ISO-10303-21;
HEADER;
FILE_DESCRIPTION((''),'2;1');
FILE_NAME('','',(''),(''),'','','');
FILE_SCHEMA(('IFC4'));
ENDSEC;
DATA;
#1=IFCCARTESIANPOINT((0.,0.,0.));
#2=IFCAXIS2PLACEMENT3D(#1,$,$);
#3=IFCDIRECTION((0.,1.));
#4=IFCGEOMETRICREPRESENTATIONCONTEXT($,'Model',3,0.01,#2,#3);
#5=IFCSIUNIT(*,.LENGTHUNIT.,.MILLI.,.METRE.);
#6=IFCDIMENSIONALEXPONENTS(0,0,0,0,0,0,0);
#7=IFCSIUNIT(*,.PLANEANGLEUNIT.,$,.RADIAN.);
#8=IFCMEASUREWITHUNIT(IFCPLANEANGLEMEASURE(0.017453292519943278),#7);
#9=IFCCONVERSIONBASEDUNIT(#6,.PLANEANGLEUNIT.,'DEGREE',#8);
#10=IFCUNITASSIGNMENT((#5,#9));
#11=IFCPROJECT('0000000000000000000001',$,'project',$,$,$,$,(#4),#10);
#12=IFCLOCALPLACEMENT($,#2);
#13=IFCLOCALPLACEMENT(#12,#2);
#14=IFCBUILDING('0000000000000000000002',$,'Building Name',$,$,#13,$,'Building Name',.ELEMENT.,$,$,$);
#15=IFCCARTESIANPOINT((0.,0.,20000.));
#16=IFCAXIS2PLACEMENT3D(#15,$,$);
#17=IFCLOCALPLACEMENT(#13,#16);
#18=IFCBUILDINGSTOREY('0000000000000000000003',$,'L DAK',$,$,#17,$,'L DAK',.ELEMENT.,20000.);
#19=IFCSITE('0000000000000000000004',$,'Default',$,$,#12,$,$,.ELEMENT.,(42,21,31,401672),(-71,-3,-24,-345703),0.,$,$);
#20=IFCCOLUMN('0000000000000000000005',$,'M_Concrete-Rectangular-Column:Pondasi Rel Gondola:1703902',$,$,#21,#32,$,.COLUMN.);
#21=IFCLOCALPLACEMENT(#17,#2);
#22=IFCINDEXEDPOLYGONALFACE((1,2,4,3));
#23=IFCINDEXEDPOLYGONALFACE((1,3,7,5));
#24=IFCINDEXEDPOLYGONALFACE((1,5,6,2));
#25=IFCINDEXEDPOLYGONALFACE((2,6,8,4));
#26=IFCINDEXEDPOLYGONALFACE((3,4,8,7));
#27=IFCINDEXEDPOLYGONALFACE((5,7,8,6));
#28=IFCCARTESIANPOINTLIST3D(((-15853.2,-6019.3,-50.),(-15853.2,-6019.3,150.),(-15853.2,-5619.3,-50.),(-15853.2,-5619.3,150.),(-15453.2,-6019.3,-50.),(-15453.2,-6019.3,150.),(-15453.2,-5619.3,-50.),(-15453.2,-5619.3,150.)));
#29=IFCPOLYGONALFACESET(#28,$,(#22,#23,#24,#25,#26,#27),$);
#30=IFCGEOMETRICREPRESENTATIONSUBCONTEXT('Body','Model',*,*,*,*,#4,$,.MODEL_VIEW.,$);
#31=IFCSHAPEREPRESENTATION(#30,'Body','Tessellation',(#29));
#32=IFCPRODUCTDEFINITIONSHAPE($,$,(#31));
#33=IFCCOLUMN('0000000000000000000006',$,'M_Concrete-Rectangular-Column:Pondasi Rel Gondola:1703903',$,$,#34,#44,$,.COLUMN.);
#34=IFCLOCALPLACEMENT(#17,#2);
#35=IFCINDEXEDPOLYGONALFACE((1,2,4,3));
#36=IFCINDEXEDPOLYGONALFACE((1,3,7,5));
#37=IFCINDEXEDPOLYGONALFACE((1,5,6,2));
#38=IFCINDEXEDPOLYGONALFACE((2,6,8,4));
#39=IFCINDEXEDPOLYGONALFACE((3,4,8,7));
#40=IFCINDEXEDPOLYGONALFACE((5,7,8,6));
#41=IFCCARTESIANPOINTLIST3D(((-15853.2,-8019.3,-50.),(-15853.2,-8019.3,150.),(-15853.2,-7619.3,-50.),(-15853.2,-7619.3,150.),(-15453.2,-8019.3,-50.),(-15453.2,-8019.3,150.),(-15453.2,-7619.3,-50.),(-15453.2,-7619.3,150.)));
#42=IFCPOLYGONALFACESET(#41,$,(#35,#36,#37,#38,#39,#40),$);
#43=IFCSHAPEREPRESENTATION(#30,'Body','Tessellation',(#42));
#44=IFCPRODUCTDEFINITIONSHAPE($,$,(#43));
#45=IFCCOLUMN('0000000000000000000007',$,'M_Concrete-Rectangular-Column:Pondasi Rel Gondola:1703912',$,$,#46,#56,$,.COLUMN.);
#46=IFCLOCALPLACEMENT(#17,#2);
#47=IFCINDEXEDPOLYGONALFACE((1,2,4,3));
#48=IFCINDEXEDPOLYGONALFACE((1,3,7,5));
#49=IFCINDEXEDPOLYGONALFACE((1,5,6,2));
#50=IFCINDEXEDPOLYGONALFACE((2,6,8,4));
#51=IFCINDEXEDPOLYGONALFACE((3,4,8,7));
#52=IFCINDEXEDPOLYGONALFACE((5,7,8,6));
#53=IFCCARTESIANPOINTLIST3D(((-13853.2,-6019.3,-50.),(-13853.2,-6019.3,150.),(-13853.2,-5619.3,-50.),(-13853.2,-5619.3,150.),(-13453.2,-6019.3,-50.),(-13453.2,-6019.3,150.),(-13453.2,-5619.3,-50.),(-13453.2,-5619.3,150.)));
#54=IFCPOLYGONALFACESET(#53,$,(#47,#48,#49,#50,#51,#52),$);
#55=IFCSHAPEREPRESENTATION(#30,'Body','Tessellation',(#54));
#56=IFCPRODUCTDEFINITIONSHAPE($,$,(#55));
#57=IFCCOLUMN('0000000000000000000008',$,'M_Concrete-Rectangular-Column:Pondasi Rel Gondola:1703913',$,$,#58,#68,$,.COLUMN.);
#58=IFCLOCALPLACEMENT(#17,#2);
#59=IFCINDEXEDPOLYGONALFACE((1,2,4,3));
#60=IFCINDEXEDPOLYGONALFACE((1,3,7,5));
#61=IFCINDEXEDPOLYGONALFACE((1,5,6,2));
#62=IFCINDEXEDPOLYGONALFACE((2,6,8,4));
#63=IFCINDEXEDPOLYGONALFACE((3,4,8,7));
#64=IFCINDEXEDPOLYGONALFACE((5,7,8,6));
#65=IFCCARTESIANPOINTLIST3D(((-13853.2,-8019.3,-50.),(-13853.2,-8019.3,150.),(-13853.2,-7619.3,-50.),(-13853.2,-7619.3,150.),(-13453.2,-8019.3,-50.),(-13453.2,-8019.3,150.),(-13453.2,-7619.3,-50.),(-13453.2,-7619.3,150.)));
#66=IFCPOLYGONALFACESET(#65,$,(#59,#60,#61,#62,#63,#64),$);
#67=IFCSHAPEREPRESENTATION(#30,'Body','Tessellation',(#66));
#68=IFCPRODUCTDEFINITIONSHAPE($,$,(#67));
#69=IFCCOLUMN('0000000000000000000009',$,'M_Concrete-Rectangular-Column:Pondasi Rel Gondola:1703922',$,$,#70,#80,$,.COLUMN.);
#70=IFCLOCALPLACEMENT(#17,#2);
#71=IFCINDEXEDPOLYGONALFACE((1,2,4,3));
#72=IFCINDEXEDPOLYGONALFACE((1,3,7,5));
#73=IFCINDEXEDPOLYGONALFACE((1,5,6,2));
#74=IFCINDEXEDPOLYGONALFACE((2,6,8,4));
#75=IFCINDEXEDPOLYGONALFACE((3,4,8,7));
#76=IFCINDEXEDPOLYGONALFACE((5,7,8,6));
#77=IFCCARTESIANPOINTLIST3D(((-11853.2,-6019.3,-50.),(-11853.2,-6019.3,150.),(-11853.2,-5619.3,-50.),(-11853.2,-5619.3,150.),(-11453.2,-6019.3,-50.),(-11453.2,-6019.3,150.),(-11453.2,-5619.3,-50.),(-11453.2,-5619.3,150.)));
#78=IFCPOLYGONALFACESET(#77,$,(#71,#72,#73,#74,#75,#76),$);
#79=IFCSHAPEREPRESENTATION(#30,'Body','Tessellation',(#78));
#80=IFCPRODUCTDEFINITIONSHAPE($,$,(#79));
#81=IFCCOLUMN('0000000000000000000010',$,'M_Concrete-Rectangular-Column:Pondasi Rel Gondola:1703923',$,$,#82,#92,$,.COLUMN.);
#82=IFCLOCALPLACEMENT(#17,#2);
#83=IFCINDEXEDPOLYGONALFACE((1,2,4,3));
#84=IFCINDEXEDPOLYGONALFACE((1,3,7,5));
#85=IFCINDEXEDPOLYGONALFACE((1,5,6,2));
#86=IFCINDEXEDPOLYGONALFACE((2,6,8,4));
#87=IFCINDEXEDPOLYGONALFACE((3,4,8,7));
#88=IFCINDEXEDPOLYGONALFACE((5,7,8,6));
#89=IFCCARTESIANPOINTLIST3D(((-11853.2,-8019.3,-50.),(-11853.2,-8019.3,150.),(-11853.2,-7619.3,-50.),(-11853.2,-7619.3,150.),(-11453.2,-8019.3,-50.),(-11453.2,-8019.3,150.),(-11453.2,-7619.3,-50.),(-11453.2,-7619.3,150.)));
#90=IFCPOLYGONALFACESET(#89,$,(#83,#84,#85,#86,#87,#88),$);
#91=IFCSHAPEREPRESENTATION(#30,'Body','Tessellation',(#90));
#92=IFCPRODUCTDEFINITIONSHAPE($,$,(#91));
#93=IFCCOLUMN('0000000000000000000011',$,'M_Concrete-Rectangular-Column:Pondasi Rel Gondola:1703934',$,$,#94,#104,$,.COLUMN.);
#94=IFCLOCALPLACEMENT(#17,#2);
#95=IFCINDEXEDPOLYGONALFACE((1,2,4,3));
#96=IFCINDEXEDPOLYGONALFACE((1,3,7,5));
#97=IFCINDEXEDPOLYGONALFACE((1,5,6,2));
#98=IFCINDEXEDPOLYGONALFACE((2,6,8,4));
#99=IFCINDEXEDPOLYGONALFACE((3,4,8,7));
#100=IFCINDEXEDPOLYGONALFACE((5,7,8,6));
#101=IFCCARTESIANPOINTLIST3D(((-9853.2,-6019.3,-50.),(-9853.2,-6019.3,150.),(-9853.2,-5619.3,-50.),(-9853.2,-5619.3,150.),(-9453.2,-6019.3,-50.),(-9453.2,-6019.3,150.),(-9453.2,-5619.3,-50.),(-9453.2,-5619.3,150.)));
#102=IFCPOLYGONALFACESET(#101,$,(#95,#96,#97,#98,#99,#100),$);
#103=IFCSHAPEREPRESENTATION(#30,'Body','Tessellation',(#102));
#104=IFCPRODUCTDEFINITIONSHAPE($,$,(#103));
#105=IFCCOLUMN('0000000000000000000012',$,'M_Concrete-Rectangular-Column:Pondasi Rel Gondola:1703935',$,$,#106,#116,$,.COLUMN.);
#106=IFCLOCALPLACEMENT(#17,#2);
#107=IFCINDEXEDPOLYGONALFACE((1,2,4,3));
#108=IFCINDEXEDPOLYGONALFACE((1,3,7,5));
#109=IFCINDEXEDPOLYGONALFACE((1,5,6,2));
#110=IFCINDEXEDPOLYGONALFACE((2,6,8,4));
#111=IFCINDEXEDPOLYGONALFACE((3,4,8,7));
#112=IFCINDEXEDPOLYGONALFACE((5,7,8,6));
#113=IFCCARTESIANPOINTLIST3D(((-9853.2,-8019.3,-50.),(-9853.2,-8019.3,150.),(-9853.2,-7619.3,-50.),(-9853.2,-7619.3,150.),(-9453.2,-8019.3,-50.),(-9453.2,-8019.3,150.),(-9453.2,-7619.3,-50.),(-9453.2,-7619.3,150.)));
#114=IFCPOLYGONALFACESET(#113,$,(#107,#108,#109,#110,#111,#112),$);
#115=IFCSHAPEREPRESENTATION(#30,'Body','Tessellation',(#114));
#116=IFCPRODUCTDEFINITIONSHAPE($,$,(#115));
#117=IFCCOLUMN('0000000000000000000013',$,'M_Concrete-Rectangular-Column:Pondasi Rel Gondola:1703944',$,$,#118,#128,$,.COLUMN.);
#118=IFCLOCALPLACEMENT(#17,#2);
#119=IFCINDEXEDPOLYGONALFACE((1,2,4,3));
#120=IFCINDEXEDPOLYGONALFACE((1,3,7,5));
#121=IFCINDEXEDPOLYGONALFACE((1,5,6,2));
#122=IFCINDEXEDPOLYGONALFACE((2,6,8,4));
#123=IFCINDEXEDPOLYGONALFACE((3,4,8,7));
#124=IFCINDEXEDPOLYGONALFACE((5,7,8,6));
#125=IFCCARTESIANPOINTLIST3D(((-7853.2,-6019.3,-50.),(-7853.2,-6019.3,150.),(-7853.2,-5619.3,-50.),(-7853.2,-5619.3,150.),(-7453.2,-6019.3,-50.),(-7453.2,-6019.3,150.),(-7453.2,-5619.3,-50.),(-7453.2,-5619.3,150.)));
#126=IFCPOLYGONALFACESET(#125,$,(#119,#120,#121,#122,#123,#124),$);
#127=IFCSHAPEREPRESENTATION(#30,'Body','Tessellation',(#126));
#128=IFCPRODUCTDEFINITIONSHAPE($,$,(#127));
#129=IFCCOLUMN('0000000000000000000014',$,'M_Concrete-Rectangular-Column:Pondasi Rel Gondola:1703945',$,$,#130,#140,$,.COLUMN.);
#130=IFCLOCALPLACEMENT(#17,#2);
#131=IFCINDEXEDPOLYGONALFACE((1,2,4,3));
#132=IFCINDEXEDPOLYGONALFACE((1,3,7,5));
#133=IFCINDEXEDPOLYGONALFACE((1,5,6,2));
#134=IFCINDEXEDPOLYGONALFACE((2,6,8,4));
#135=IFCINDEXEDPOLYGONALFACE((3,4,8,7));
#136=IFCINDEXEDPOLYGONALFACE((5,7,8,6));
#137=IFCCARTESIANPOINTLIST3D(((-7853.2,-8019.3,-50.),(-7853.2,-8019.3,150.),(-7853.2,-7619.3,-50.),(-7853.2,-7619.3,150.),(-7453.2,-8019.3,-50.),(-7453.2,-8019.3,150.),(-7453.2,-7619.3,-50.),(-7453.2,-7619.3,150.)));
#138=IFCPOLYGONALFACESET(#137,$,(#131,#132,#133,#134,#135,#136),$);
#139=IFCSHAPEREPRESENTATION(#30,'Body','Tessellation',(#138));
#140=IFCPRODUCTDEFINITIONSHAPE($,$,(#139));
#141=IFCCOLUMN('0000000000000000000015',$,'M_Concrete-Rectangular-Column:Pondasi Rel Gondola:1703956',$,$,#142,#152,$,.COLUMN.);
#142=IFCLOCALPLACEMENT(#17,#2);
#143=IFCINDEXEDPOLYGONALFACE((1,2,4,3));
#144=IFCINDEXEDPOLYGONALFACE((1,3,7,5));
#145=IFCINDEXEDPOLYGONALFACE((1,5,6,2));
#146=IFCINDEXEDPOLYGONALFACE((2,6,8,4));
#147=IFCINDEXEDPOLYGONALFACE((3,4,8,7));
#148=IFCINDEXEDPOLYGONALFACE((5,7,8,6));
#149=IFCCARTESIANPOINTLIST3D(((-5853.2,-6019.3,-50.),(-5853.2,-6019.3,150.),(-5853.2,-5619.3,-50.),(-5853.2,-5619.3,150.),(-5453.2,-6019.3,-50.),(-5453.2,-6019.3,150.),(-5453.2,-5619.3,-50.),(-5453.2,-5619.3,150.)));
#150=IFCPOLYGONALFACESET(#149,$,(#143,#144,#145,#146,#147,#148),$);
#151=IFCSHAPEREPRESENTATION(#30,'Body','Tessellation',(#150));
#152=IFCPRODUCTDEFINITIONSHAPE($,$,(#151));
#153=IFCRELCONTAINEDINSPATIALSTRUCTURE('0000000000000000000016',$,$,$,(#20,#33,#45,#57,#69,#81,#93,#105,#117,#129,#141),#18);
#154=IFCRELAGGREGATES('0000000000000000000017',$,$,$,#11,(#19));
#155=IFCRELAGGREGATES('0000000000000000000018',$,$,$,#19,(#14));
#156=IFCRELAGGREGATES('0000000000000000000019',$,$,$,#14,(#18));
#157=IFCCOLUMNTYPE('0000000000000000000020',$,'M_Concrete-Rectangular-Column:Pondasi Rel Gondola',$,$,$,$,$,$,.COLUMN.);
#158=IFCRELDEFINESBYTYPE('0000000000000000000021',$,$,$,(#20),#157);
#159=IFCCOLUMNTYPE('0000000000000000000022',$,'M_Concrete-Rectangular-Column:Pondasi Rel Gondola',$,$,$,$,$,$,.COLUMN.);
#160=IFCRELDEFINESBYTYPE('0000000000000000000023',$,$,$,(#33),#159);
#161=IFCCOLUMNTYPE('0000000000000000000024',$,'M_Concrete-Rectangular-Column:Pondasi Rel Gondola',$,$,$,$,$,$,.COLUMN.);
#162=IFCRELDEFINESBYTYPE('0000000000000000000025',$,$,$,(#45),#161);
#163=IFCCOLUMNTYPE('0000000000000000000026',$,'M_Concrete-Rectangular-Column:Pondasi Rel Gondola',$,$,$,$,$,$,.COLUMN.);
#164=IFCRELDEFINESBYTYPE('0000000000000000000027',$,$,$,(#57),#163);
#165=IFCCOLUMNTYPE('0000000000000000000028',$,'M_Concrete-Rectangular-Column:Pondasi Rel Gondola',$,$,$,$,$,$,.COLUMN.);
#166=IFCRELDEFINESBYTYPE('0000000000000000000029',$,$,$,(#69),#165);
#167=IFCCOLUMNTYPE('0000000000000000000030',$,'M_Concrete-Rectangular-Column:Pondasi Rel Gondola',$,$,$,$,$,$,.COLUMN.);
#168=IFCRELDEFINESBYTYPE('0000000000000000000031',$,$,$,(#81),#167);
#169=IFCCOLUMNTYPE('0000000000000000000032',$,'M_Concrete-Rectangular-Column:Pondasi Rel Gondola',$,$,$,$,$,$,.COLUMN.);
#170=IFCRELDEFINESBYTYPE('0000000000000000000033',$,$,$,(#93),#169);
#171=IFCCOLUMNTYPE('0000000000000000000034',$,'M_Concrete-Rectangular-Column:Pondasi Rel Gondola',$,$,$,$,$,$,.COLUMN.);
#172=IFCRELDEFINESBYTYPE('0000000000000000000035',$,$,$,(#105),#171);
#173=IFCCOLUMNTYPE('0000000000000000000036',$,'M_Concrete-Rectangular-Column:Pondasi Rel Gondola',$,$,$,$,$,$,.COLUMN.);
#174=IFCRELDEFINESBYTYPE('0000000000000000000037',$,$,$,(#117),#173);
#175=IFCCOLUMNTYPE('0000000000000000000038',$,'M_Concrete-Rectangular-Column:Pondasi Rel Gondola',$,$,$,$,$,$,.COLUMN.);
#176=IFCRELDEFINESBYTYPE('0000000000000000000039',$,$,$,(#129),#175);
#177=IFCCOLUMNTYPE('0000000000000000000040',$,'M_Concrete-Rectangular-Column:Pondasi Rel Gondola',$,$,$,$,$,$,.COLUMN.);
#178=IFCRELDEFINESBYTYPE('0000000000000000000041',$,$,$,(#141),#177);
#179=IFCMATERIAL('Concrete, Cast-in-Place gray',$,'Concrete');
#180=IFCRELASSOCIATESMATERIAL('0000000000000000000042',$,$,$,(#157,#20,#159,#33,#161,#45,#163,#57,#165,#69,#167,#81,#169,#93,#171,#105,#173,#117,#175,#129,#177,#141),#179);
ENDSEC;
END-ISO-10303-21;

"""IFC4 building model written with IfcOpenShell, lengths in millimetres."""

from ifc_helpers import new_model, entity, si_unit, converted_unit, direction, frame, origin, place, context, subcontext, project, spatial, indexed_curve, outline, extrude, source, transform, mapped, material, type_object, type_shapes, element, save


model = new_model("IFC4")

# Units and contexts
model_context = context("Model", 3, precision=0.01, world=origin(), true_north=direction((0.0, 1.0)))
body_context = subcontext(model_context, "Body", "Model", "MODEL_VIEW")
ifc_project = project(units=[si_unit("LENGTHUNIT", "METRE", prefix="MILLI"), converted_unit("PLANEANGLEUNIT", "DEGREE", entity("IfcPlaneAngleMeasure", 0.017453292519943278), si_unit("PLANEANGLEUNIT", "RADIAN"), dimensions=[0, 0, 0, 0, 0, 0, 0])], contexts=[model_context])

# Site, building, storey
site_placement = place(None, origin())
site = spatial("IfcSite", under=ifc_project, at=site_placement, Name="Default", CompositionType="ELEMENT", RefLatitude=(42, 21, 31, 401672), RefLongitude=(-71, -3, -24, -345703), RefElevation=0.0)
building_placement = place(site_placement, origin())
building = spatial("IfcBuilding", under=site, at=building_placement, Name="Building Name", LongName="Building Name", CompositionType="ELEMENT")
storey_placement = place(building_placement, frame((0.0, 0.0, 20000.0)))
storey = spatial("IfcBuildingStorey", under=building, at=storey_placement, Name="L DAK", LongName="L DAK", CompositionType="ELEMENT", Elevation=20000.0)

# Columns
ifc_material = material(Name="Concrete, Cast-in-Place gray", Category="Concrete")
column_type_1 = type_object("IfcColumnType", Name="M_Concrete-Rectangular-Column:Pondasi Rel Gondola", PredefinedType="COLUMN", material=ifc_material)
shared_shape_1 = source(origin(), body_context, "Body", "SweptSolid", [
    extrude(outline(indexed_curve([(-200.0, -200.0), (200.0, -200.0), (200.0, 200.0), (-200.0, 200.0), (-200.0, -200.0)], self_intersect=False)), frame((-15653.2, -5819.3, 19950.0), z_axis=(0.0, 0.0, 1.0), x_axis=(-1.0, 0.0, 0.0)), (0.0, 0.0, 1.0), 200.0),
])
type_shapes(column_type_1, [shared_shape_1])
column_1_placement = place(storey_placement, frame((0.0, 0.0, -20000.0)))
element("IfcColumn", 1, at=column_1_placement, inside=storey, type_object=column_type_1, material=ifc_material, Name="M_Concrete-Rectangular-Column:Pondasi Rel Gondola:1703902", PredefinedType="COLUMN", context=body_context, shape_type="MappedRepresentation", body=[
    mapped(shared_shape_1, transform((0.0, 0.0, 0.0), scale=1.0)),
])
column_type_2 = type_object("IfcColumnType", Name="M_Concrete-Rectangular-Column:Pondasi Rel Gondola", PredefinedType="COLUMN", material=ifc_material)
shared_shape_2 = source(origin(), body_context, "Body", "SweptSolid", [
    extrude(outline(indexed_curve([(-200.0, -200.0), (200.0, -200.0), (200.0, 200.0), (-200.0, 200.0), (-200.0, -200.0)], self_intersect=False)), frame((-15653.2, -7819.3, 19950.0), z_axis=(0.0, 0.0, 1.0), x_axis=(-1.0, 0.0, 0.0)), (0.0, 0.0, 1.0), 200.0),
])
type_shapes(column_type_2, [shared_shape_2])
column_2_placement = place(storey_placement, frame((0.0, 0.0, -20000.0)))
element("IfcColumn", 2, at=column_2_placement, inside=storey, type_object=column_type_2, material=ifc_material, Name="M_Concrete-Rectangular-Column:Pondasi Rel Gondola:1703903", PredefinedType="COLUMN", context=body_context, shape_type="MappedRepresentation", body=[
    mapped(shared_shape_2, transform((0.0, 0.0, 0.0), scale=1.0)),
])
column_type_3 = type_object("IfcColumnType", Name="M_Concrete-Rectangular-Column:Pondasi Rel Gondola", PredefinedType="COLUMN", material=ifc_material)
shared_shape_3 = source(origin(), body_context, "Body", "SweptSolid", [
    extrude(outline(indexed_curve([(-200.0, -200.0), (200.0, -200.0), (200.0, 200.0), (-200.0, 200.0), (-200.0, -200.0)], self_intersect=False)), frame((-13653.2, -5819.3, 19950.0), z_axis=(0.0, 0.0, 1.0), x_axis=(-1.0, 0.0, 0.0)), (0.0, 0.0, 1.0), 200.0),
])
type_shapes(column_type_3, [shared_shape_3])
column_3_placement = place(storey_placement, frame((0.0, 0.0, -20000.0)))
element("IfcColumn", 3, at=column_3_placement, inside=storey, type_object=column_type_3, material=ifc_material, Name="M_Concrete-Rectangular-Column:Pondasi Rel Gondola:1703912", PredefinedType="COLUMN", context=body_context, shape_type="MappedRepresentation", body=[
    mapped(shared_shape_3, transform((0.0, 0.0, 0.0), scale=1.0)),
])
column_type_4 = type_object("IfcColumnType", Name="M_Concrete-Rectangular-Column:Pondasi Rel Gondola", PredefinedType="COLUMN", material=ifc_material)
shared_shape_4 = source(origin(), body_context, "Body", "SweptSolid", [
    extrude(outline(indexed_curve([(-200.0, -200.0), (200.0, -200.0), (200.0, 200.0), (-200.0, 200.0), (-200.0, -200.0)], self_intersect=False)), frame((-13653.2, -7819.3, 19950.0), z_axis=(0.0, 0.0, 1.0), x_axis=(-1.0, 0.0, 0.0)), (0.0, 0.0, 1.0), 200.0),
])
type_shapes(column_type_4, [shared_shape_4])
column_4_placement = place(storey_placement, frame((0.0, 0.0, -20000.0)))
element("IfcColumn", 4, at=column_4_placement, inside=storey, type_object=column_type_4, material=ifc_material, Name="M_Concrete-Rectangular-Column:Pondasi Rel Gondola:1703913", PredefinedType="COLUMN", context=body_context, shape_type="MappedRepresentation", body=[
    mapped(shared_shape_4, transform((0.0, 0.0, 0.0), scale=1.0)),
])
column_type_5 = type_object("IfcColumnType", Name="M_Concrete-Rectangular-Column:Pondasi Rel Gondola", PredefinedType="COLUMN", material=ifc_material)
shared_shape_5 = source(origin(), body_context, "Body", "SweptSolid", [
    extrude(outline(indexed_curve([(-200.0, -200.0), (200.0, -200.0), (200.0, 200.0), (-200.0, 200.0), (-200.0, -200.0)], self_intersect=False)), frame((-11653.2, -5819.3, 19950.0), z_axis=(0.0, 0.0, 1.0), x_axis=(-1.0, 0.0, 0.0)), (0.0, 0.0, 1.0), 200.0),
])
type_shapes(column_type_5, [shared_shape_5])
column_5_placement = place(storey_placement, frame((0.0, 0.0, -20000.0)))
element("IfcColumn", 5, at=column_5_placement, inside=storey, type_object=column_type_5, material=ifc_material, Name="M_Concrete-Rectangular-Column:Pondasi Rel Gondola:1703922", PredefinedType="COLUMN", context=body_context, shape_type="MappedRepresentation", body=[
    mapped(shared_shape_5, transform((0.0, 0.0, 0.0), scale=1.0)),
])
column_type_6 = type_object("IfcColumnType", Name="M_Concrete-Rectangular-Column:Pondasi Rel Gondola", PredefinedType="COLUMN", material=ifc_material)
shared_shape_6 = source(origin(), body_context, "Body", "SweptSolid", [
    extrude(outline(indexed_curve([(-200.0, -200.0), (200.0, -200.0), (200.0, 200.0), (-200.0, 200.0), (-200.0, -200.0)], self_intersect=False)), frame((-11653.2, -7819.3, 19950.0), z_axis=(0.0, 0.0, 1.0), x_axis=(-1.0, 0.0, 0.0)), (0.0, 0.0, 1.0), 200.0),
])
type_shapes(column_type_6, [shared_shape_6])
column_6_placement = place(storey_placement, frame((0.0, 0.0, -20000.0)))
element("IfcColumn", 6, at=column_6_placement, inside=storey, type_object=column_type_6, material=ifc_material, Name="M_Concrete-Rectangular-Column:Pondasi Rel Gondola:1703923", PredefinedType="COLUMN", context=body_context, shape_type="MappedRepresentation", body=[
    mapped(shared_shape_6, transform((0.0, 0.0, 0.0), scale=1.0)),
])
column_type_7 = type_object("IfcColumnType", Name="M_Concrete-Rectangular-Column:Pondasi Rel Gondola", PredefinedType="COLUMN", material=ifc_material)
shared_shape_7 = source(origin(), body_context, "Body", "SweptSolid", [
    extrude(outline(indexed_curve([(-200.0, -200.0), (200.0, -200.0), (200.0, 200.0), (-200.0, 200.0), (-200.0, -200.0)], self_intersect=False)), frame((-9653.2, -5819.3, 19950.0), z_axis=(0.0, 0.0, 1.0), x_axis=(-1.0, 0.0, 0.0)), (0.0, 0.0, 1.0), 200.0),
])
type_shapes(column_type_7, [shared_shape_7])
column_7_placement = place(storey_placement, frame((0.0, 0.0, -20000.0)))
element("IfcColumn", 7, at=column_7_placement, inside=storey, type_object=column_type_7, material=ifc_material, Name="M_Concrete-Rectangular-Column:Pondasi Rel Gondola:1703934", PredefinedType="COLUMN", context=body_context, shape_type="MappedRepresentation", body=[
    mapped(shared_shape_7, transform((0.0, 0.0, 0.0), scale=1.0)),
])
column_type_8 = type_object("IfcColumnType", Name="M_Concrete-Rectangular-Column:Pondasi Rel Gondola", PredefinedType="COLUMN", material=ifc_material)
shared_shape_8 = source(origin(), body_context, "Body", "SweptSolid", [
    extrude(outline(indexed_curve([(-200.0, -200.0), (200.0, -200.0), (200.0, 200.0), (-200.0, 200.0), (-200.0, -200.0)], self_intersect=False)), frame((-9653.2, -7819.3, 19950.0), z_axis=(0.0, 0.0, 1.0), x_axis=(-1.0, 0.0, 0.0)), (0.0, 0.0, 1.0), 200.0),
])
type_shapes(column_type_8, [shared_shape_8])
column_8_placement = place(storey_placement, frame((0.0, 0.0, -20000.0)))
element("IfcColumn", 8, at=column_8_placement, inside=storey, type_object=column_type_8, material=ifc_material, Name="M_Concrete-Rectangular-Column:Pondasi Rel Gondola:1703935", PredefinedType="COLUMN", context=body_context, shape_type="MappedRepresentation", body=[
    mapped(shared_shape_8, transform((0.0, 0.0, 0.0), scale=1.0)),
])
column_type_9 = type_object("IfcColumnType", Name="M_Concrete-Rectangular-Column:Pondasi Rel Gondola", PredefinedType="COLUMN", material=ifc_material)
shared_shape_9 = source(origin(), body_context, "Body", "SweptSolid", [
    extrude(outline(indexed_curve([(-200.0, -200.0), (200.0, -200.0), (200.0, 200.0), (-200.0, 200.0), (-200.0, -200.0)], self_intersect=False)), frame((-7653.2, -5819.3, 19950.0), z_axis=(0.0, 0.0, 1.0), x_axis=(-1.0, 0.0, 0.0)), (0.0, 0.0, 1.0), 200.0),
])
type_shapes(column_type_9, [shared_shape_9])
column_9_placement = place(storey_placement, frame((0.0, 0.0, -20000.0)))
element("IfcColumn", 9, at=column_9_placement, inside=storey, type_object=column_type_9, material=ifc_material, Name="M_Concrete-Rectangular-Column:Pondasi Rel Gondola:1703944", PredefinedType="COLUMN", context=body_context, shape_type="MappedRepresentation", body=[
    mapped(shared_shape_9, transform((0.0, 0.0, 0.0), scale=1.0)),
])
column_type_10 = type_object("IfcColumnType", Name="M_Concrete-Rectangular-Column:Pondasi Rel Gondola", PredefinedType="COLUMN", material=ifc_material)
shared_shape_10 = source(origin(), body_context, "Body", "SweptSolid", [
    extrude(outline(indexed_curve([(-200.0, -200.0), (200.0, -200.0), (200.0, 200.0), (-200.0, 200.0), (-200.0, -200.0)], self_intersect=False)), frame((-7653.2, -7819.3, 19950.0), z_axis=(0.0, 0.0, 1.0), x_axis=(-1.0, 0.0, 0.0)), (0.0, 0.0, 1.0), 200.0),
])
type_shapes(column_type_10, [shared_shape_10])
column_10_placement = place(storey_placement, frame((0.0, 0.0, -20000.0)))
element("IfcColumn", 10, at=column_10_placement, inside=storey, type_object=column_type_10, material=ifc_material, Name="M_Concrete-Rectangular-Column:Pondasi Rel Gondola:1703945", PredefinedType="COLUMN", context=body_context, shape_type="MappedRepresentation", body=[
    mapped(shared_shape_10, transform((0.0, 0.0, 0.0), scale=1.0)),
])
column_type_11 = type_object("IfcColumnType", Name="M_Concrete-Rectangular-Column:Pondasi Rel Gondola", PredefinedType="COLUMN", material=ifc_material)
shared_shape_11 = source(origin(), body_context, "Body", "SweptSolid", [
    extrude(outline(indexed_curve([(-200.0, -200.0), (200.0, -200.0), (200.0, 200.0), (-200.0, 200.0), (-200.0, -200.0)], self_intersect=False)), frame((-5653.2, -5819.3, 19950.0), z_axis=(0.0, 0.0, 1.0), x_axis=(-1.0, 0.0, 0.0)), (0.0, 0.0, 1.0), 200.0),
])
type_shapes(column_type_11, [shared_shape_11])
column_11_placement = place(storey_placement, frame((0.0, 0.0, -20000.0)))
element("IfcColumn", 11, at=column_11_placement, inside=storey, type_object=column_type_11, material=ifc_material, Name="M_Concrete-Rectangular-Column:Pondasi Rel Gondola:1703956", PredefinedType="COLUMN", context=body_context, shape_type="MappedRepresentation", body=[
    mapped(shared_shape_11, transform((0.0, 0.0, 0.0), scale=1.0)),
])

save(model, "model.ifc")
